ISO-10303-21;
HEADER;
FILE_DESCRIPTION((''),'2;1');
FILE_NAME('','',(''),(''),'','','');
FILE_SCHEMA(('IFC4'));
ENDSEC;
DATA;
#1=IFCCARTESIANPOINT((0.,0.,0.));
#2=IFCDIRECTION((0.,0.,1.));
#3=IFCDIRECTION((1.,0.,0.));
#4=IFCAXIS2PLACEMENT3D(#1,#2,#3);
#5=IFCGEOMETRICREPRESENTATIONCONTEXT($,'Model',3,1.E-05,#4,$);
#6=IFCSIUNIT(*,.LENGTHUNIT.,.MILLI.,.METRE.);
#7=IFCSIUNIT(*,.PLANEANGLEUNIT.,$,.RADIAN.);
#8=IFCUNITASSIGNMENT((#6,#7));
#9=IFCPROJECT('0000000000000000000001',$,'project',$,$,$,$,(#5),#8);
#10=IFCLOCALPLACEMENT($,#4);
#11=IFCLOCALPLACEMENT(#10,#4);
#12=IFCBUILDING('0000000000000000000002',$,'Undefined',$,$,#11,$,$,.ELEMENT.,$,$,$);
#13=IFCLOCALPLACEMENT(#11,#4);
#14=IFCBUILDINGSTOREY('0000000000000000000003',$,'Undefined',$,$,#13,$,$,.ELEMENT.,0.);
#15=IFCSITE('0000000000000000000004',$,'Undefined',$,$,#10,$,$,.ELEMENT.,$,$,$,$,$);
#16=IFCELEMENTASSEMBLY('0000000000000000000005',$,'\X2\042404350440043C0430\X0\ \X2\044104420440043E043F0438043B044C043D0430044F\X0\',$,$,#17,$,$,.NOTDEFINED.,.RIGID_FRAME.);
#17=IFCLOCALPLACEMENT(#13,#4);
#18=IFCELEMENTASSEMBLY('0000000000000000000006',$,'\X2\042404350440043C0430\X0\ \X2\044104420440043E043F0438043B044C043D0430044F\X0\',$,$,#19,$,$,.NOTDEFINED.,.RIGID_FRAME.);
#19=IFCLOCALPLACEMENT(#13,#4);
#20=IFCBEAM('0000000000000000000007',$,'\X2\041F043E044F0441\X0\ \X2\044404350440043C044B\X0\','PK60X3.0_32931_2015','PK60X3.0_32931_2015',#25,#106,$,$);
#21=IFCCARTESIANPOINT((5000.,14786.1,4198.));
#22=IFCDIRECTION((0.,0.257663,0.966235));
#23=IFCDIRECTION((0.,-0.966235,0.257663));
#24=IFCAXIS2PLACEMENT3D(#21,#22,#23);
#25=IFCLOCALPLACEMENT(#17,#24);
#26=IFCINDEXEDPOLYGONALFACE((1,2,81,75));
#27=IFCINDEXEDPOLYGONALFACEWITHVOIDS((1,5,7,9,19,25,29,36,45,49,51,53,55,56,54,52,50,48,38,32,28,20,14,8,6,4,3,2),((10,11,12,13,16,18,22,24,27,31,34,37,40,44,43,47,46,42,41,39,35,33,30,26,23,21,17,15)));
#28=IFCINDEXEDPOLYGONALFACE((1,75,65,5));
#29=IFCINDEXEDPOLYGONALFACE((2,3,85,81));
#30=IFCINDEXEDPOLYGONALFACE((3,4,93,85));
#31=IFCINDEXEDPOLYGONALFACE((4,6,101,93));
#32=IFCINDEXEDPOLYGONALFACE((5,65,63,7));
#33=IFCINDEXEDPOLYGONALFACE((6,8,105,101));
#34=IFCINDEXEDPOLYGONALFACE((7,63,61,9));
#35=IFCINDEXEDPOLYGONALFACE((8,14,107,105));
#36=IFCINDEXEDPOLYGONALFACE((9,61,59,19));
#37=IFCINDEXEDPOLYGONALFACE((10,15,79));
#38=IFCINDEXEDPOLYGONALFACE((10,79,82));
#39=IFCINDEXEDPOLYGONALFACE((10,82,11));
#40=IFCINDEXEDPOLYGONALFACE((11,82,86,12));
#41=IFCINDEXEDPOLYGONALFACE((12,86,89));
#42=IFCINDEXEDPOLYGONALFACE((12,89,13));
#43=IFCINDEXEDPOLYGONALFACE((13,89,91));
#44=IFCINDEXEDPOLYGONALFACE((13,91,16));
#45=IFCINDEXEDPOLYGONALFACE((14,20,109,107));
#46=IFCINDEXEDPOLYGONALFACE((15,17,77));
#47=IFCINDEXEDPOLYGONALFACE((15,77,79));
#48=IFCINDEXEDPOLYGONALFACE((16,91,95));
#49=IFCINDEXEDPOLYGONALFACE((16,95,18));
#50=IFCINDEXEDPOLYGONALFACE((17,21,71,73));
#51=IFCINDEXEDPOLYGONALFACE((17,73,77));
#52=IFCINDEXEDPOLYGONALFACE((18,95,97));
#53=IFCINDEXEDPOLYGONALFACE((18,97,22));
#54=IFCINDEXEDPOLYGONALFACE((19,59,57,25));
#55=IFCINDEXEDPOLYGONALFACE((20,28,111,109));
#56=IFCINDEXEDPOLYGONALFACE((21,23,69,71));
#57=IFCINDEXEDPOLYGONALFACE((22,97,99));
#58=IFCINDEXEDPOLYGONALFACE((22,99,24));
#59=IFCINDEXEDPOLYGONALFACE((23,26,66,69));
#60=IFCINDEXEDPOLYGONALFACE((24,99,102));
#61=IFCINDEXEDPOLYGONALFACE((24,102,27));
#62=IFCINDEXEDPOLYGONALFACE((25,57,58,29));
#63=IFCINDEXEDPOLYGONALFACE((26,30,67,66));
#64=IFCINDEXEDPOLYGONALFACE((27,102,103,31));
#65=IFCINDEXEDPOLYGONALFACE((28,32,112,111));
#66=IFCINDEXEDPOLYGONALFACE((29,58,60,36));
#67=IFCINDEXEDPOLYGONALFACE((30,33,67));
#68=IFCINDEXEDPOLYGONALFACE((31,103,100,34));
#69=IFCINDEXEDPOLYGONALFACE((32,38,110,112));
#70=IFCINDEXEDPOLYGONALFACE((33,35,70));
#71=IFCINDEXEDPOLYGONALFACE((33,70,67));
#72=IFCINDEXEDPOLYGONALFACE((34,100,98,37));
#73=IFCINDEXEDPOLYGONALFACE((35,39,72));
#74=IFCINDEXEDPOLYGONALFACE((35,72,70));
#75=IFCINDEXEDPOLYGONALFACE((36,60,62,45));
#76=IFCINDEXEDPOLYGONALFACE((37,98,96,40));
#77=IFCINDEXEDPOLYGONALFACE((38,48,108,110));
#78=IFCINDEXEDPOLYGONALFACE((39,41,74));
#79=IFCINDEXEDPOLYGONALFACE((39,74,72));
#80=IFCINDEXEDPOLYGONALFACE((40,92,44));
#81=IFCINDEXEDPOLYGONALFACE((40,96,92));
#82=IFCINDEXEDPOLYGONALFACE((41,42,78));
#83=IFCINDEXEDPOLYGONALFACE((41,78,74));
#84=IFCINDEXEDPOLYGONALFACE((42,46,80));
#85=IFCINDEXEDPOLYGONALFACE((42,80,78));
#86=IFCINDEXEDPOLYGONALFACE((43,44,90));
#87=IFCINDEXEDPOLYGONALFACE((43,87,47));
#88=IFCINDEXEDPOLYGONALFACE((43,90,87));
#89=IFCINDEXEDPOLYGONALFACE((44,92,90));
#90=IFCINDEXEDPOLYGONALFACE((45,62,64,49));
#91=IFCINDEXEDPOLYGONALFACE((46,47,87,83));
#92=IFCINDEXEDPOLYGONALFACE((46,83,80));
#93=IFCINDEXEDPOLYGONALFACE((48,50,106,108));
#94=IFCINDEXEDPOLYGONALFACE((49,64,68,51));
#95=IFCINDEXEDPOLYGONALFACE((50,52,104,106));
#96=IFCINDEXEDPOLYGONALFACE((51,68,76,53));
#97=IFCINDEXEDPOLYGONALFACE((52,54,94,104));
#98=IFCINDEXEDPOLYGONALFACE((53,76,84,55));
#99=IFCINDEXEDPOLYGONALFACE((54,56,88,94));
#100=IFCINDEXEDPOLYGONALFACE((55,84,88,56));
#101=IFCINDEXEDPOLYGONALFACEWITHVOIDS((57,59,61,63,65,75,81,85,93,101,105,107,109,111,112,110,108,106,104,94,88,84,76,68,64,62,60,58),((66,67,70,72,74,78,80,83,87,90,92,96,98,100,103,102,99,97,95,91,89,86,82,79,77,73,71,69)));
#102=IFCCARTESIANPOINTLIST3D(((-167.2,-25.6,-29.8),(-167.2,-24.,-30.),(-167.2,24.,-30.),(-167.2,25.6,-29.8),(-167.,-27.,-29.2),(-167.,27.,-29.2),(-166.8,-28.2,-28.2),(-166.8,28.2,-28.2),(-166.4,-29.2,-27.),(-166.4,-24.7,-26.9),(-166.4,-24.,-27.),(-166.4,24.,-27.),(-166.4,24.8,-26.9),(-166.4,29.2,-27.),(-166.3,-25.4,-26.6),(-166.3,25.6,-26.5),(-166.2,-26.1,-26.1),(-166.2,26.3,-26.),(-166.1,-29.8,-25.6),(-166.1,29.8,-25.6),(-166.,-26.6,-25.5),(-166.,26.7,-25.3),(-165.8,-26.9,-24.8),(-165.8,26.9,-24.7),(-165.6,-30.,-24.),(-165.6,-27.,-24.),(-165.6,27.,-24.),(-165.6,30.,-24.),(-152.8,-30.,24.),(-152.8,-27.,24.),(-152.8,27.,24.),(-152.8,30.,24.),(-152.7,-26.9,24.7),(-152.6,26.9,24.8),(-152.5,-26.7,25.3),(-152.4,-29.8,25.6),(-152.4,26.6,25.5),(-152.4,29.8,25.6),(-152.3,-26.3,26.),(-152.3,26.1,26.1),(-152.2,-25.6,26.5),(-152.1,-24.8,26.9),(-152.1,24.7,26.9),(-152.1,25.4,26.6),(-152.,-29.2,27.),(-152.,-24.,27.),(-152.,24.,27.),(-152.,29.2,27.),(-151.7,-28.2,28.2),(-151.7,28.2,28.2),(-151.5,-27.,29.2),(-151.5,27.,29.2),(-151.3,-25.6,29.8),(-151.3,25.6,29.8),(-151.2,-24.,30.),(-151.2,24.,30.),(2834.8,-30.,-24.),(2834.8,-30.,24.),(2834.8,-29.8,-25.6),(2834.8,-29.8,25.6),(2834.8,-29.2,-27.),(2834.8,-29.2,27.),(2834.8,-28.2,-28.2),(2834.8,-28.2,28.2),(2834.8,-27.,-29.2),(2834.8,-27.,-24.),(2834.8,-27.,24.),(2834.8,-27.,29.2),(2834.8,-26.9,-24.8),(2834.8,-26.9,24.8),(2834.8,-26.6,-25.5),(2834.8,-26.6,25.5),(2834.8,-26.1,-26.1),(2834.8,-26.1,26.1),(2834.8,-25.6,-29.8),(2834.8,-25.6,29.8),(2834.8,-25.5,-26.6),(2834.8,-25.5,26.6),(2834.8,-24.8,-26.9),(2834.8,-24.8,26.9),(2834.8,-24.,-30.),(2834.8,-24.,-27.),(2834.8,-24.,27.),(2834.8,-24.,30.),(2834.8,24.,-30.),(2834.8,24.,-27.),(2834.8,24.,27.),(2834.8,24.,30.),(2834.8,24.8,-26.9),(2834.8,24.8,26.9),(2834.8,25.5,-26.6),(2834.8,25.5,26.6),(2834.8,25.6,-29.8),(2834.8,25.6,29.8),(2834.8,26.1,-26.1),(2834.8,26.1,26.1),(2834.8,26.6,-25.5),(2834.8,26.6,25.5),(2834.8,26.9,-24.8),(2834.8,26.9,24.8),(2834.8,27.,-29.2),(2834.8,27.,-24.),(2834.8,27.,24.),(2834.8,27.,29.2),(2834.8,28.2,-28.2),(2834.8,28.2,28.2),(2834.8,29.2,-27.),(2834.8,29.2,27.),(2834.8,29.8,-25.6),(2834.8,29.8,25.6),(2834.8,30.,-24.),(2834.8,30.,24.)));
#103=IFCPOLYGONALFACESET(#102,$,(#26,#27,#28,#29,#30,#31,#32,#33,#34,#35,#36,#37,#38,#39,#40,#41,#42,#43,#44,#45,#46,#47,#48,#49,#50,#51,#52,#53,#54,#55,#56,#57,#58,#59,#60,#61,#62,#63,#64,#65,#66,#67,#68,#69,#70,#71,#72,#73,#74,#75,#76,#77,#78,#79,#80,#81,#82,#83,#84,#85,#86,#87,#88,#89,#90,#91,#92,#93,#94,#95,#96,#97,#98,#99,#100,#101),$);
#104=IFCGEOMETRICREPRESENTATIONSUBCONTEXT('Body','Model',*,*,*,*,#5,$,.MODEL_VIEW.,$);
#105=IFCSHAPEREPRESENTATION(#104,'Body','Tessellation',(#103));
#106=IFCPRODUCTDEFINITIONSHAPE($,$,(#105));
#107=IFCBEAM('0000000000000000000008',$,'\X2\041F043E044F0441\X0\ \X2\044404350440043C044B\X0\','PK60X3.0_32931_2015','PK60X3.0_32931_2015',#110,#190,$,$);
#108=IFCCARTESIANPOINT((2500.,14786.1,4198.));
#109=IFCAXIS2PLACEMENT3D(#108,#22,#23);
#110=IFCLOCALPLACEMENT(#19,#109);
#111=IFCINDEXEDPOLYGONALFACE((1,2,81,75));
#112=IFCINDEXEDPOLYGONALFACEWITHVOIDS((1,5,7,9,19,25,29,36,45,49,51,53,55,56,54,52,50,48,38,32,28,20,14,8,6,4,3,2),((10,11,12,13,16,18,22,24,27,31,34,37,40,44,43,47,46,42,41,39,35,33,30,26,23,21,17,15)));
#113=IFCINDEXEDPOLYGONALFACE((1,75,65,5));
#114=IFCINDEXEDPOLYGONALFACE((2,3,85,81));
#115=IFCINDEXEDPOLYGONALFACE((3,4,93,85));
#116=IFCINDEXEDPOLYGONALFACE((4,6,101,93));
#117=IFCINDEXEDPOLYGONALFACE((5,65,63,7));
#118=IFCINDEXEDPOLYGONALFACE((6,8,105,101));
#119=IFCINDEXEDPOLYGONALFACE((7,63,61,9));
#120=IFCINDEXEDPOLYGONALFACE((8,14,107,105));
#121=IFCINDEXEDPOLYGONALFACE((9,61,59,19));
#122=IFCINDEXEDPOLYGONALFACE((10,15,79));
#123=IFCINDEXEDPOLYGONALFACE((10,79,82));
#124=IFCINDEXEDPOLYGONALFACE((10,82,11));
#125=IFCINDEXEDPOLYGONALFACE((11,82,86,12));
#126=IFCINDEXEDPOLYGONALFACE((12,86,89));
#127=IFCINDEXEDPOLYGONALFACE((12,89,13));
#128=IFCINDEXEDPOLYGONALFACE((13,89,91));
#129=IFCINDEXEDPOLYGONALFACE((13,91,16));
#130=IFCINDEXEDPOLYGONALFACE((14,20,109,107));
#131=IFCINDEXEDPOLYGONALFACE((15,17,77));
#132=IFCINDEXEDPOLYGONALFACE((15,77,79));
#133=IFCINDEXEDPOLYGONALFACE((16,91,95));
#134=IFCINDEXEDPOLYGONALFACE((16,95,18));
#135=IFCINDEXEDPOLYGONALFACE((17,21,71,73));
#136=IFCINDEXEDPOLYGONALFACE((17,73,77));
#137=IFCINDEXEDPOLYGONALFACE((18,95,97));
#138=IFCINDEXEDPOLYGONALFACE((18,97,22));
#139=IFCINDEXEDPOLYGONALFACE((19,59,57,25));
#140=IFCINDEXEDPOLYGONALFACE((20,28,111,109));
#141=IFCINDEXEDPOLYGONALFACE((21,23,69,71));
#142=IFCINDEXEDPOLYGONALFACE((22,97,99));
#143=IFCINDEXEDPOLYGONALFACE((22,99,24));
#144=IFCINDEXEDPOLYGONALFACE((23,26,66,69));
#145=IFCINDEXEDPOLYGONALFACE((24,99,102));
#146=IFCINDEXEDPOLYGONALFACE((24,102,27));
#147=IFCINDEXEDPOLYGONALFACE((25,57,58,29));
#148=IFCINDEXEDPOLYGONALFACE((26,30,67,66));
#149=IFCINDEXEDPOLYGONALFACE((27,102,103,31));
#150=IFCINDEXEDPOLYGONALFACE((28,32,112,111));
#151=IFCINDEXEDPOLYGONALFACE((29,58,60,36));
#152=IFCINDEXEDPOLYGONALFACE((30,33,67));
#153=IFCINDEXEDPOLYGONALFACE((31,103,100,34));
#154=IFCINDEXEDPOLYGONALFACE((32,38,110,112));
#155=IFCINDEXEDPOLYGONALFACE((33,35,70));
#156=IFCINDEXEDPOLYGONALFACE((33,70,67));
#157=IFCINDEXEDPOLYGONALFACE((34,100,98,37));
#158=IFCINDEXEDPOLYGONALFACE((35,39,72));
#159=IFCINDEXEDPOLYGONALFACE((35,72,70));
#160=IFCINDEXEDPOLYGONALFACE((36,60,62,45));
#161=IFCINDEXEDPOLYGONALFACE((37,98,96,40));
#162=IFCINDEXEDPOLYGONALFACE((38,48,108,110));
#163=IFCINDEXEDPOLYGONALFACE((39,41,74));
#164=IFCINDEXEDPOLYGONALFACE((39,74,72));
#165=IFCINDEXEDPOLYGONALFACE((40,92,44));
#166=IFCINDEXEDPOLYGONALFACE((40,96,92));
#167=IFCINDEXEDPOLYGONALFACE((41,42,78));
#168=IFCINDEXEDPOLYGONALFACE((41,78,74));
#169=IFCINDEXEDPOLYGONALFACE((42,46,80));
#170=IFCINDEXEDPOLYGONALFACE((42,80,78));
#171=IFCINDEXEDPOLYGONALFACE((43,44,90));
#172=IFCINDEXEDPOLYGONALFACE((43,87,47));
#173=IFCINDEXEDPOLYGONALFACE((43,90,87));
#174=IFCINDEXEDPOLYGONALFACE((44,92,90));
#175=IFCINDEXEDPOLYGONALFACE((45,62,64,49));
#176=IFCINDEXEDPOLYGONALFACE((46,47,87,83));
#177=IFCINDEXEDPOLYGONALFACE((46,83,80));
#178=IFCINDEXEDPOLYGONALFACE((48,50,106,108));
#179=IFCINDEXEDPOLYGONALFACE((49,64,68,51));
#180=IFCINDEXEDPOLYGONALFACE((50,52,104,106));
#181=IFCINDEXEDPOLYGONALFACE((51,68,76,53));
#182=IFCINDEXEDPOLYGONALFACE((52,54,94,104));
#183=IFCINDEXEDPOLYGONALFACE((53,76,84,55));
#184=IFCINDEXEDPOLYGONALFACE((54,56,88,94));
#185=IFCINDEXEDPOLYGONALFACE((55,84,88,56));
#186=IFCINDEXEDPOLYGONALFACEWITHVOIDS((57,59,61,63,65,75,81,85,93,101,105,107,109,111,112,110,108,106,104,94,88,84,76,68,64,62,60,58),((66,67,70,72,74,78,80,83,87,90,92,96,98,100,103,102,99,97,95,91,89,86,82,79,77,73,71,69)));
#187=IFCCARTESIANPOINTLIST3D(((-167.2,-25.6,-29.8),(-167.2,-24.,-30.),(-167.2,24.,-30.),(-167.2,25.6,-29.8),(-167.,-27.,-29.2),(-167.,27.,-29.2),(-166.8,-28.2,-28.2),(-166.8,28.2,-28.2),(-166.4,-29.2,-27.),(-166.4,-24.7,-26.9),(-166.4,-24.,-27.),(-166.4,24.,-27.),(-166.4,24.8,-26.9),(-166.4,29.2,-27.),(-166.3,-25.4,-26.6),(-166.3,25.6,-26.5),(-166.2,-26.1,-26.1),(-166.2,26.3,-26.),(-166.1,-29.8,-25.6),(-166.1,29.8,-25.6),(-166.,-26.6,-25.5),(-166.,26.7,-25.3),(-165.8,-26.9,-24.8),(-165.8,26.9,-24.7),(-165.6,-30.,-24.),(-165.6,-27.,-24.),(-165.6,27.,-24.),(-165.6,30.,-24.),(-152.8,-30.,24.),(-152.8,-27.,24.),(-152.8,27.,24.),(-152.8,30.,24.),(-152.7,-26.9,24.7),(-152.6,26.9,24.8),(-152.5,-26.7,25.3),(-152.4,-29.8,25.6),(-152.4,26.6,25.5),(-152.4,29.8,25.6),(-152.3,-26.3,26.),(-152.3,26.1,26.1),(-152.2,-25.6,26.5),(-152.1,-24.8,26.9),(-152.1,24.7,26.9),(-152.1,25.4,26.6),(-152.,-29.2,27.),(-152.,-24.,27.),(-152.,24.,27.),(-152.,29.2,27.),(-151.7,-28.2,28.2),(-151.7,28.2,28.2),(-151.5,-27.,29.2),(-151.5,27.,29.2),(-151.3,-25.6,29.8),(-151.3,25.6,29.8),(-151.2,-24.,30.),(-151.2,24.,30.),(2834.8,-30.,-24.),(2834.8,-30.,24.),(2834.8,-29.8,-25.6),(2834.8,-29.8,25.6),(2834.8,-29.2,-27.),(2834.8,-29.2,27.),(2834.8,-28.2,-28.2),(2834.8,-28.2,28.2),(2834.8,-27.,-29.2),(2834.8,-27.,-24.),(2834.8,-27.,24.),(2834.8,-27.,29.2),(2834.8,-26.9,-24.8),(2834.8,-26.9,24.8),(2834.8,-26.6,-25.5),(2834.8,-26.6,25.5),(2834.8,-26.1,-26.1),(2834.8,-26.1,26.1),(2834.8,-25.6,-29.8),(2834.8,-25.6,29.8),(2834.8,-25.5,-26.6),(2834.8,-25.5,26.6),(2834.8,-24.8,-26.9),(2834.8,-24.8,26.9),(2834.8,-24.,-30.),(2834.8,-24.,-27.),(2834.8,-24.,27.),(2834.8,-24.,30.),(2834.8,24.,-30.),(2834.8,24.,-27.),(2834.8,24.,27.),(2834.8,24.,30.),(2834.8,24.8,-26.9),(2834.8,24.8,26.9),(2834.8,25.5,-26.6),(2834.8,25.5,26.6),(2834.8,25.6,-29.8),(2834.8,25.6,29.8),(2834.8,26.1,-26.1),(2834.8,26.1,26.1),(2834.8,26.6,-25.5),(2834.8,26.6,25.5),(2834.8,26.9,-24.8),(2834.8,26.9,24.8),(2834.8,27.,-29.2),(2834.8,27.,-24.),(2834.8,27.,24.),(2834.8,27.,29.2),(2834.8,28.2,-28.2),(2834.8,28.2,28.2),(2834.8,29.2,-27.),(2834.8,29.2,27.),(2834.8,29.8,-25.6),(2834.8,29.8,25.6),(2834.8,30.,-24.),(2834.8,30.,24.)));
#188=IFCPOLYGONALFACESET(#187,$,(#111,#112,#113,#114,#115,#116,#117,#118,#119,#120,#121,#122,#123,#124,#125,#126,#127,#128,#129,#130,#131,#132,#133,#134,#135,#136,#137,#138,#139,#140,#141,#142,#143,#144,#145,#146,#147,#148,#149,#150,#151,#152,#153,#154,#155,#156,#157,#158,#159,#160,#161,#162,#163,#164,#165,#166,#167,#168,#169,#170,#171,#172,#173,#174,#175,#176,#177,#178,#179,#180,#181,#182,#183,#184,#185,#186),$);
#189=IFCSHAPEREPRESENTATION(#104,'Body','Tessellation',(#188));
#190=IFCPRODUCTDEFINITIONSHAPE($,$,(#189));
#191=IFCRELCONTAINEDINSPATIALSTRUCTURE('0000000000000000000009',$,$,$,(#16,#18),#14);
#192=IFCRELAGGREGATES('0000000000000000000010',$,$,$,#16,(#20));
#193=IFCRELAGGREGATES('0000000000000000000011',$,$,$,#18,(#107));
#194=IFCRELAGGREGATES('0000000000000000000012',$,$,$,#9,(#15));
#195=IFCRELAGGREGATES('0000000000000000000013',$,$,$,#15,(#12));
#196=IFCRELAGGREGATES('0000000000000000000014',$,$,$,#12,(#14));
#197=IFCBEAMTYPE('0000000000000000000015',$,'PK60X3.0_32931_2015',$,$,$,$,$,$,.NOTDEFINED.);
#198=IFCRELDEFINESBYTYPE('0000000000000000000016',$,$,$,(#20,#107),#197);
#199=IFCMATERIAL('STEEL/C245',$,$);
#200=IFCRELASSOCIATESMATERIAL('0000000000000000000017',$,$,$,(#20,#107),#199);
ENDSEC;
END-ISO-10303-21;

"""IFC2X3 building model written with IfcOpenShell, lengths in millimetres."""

from ifc_helpers import new_model, si_unit, frame, origin_with_axes, origin_2d_with_axis, place, context, subcontext, project, spatial, hollow_rectangle, extrude, clip, halfspace, material, type_object, element, aggregate, save


model = new_model("IFC2X3")

# Units and contexts
model_context = context("Model", 3, precision=1e-05, world=origin_with_axes())
body_context = subcontext(model_context, "Body", "Model", "MODEL_VIEW")
ifc_project = project(units=[si_unit("LENGTHUNIT", "METRE", prefix="MILLI"), si_unit("PLANEANGLEUNIT", "RADIAN")], contexts=[model_context])

# Site, building, storey
site_placement = place(None, origin_with_axes())
site = spatial("IfcSite", under=ifc_project, at=site_placement, Name="Undefined", CompositionType="ELEMENT")
building_placement = place(site_placement, origin_with_axes())
building = spatial("IfcBuilding", under=site, at=building_placement, Name="Undefined", CompositionType="ELEMENT")
storey_placement = place(building_placement, origin_with_axes())
storey = spatial("IfcBuildingStorey", under=building, at=storey_placement, Name="Undefined", CompositionType="ELEMENT", Elevation=0.0)

# Element assemblies
assembly_1_placement = place(storey_placement, origin_with_axes())
assembly_1 = element("IfcElementAssembly", 1, at=assembly_1_placement, inside=storey, Name="Ферма стропильная", AssemblyPlace="NOTDEFINED", PredefinedType="RIGID_FRAME")
ifc_material_1 = material(Name="STEEL/C245")
assembly_2_placement = place(storey_placement, origin_with_axes())
assembly_2 = element("IfcElementAssembly", 2, at=assembly_2_placement, inside=storey, Name="Ферма стропильная", AssemblyPlace="NOTDEFINED", PredefinedType="RIGID_FRAME")

# Beams
beam_type_1 = type_object("IfcBeamType", Name="PK60X3.0_32931_2015", PredefinedType="NOTDEFINED")
beam_1_placement = place(assembly_1_placement, frame((5000.0, 14786.1, 4198.0), z_axis=(0.0, 0.257663, 0.966235), x_axis=(0.0, -0.966235, 0.257663)))
beam_1 = element("IfcBeam", 3, at=beam_1_placement, type_object=beam_type_1, material=ifc_material_1, Name="Пояс фермы", Description="PK60X3.0_32931_2015", ObjectType="PK60X3.0_32931_2015", context=body_context, shape_type="Clipping", body=[
    clip(extrude(hollow_rectangle(XDim=60.0, YDim=60.0, WallThickness=3.0, InnerFilletRadius=3.0, OuterFilletRadius=6.0, at=origin_2d_with_axis()), frame((2834.8, 0.0, 0.0), z_axis=(-1.0, 0.0, 0.0), x_axis=(0.0, -1.0, 0.0)), (0.0, 0.0, 1.0), 3017.2), halfspace(frame((-162.3, 0.0, -11.5), z_axis=(0.966235, 0.0, -0.257663), x_axis=(0.257663, 0.0, 0.966235)), True)),
])
aggregate(assembly_1, [beam_1])
beam_2_placement = place(assembly_2_placement, frame((2500.0, 14786.1, 4198.0), z_axis=(0.0, 0.257663, 0.966235), x_axis=(0.0, -0.966235, 0.257663)))
beam_2 = element("IfcBeam", 4, at=beam_2_placement, type_object=beam_type_1, material=ifc_material_1, Name="Пояс фермы", Description="PK60X3.0_32931_2015", ObjectType="PK60X3.0_32931_2015", context=body_context, shape_type="Clipping", body=[
    clip(extrude(hollow_rectangle(XDim=60.0, YDim=60.0, WallThickness=3.0, InnerFilletRadius=3.0, OuterFilletRadius=6.0, at=origin_2d_with_axis()), frame((2834.8, 0.0, 0.0), z_axis=(-1.0, 0.0, 0.0), x_axis=(0.0, -1.0, 0.0)), (0.0, 0.0, 1.0), 3017.2), halfspace(frame((-162.3, 0.0, -11.5), z_axis=(0.966235, 0.0, -0.257663), x_axis=(0.257663, 0.0, 0.966235)), True)),
])
aggregate(assembly_2, [beam_2])

save(model, "model.ifc")
